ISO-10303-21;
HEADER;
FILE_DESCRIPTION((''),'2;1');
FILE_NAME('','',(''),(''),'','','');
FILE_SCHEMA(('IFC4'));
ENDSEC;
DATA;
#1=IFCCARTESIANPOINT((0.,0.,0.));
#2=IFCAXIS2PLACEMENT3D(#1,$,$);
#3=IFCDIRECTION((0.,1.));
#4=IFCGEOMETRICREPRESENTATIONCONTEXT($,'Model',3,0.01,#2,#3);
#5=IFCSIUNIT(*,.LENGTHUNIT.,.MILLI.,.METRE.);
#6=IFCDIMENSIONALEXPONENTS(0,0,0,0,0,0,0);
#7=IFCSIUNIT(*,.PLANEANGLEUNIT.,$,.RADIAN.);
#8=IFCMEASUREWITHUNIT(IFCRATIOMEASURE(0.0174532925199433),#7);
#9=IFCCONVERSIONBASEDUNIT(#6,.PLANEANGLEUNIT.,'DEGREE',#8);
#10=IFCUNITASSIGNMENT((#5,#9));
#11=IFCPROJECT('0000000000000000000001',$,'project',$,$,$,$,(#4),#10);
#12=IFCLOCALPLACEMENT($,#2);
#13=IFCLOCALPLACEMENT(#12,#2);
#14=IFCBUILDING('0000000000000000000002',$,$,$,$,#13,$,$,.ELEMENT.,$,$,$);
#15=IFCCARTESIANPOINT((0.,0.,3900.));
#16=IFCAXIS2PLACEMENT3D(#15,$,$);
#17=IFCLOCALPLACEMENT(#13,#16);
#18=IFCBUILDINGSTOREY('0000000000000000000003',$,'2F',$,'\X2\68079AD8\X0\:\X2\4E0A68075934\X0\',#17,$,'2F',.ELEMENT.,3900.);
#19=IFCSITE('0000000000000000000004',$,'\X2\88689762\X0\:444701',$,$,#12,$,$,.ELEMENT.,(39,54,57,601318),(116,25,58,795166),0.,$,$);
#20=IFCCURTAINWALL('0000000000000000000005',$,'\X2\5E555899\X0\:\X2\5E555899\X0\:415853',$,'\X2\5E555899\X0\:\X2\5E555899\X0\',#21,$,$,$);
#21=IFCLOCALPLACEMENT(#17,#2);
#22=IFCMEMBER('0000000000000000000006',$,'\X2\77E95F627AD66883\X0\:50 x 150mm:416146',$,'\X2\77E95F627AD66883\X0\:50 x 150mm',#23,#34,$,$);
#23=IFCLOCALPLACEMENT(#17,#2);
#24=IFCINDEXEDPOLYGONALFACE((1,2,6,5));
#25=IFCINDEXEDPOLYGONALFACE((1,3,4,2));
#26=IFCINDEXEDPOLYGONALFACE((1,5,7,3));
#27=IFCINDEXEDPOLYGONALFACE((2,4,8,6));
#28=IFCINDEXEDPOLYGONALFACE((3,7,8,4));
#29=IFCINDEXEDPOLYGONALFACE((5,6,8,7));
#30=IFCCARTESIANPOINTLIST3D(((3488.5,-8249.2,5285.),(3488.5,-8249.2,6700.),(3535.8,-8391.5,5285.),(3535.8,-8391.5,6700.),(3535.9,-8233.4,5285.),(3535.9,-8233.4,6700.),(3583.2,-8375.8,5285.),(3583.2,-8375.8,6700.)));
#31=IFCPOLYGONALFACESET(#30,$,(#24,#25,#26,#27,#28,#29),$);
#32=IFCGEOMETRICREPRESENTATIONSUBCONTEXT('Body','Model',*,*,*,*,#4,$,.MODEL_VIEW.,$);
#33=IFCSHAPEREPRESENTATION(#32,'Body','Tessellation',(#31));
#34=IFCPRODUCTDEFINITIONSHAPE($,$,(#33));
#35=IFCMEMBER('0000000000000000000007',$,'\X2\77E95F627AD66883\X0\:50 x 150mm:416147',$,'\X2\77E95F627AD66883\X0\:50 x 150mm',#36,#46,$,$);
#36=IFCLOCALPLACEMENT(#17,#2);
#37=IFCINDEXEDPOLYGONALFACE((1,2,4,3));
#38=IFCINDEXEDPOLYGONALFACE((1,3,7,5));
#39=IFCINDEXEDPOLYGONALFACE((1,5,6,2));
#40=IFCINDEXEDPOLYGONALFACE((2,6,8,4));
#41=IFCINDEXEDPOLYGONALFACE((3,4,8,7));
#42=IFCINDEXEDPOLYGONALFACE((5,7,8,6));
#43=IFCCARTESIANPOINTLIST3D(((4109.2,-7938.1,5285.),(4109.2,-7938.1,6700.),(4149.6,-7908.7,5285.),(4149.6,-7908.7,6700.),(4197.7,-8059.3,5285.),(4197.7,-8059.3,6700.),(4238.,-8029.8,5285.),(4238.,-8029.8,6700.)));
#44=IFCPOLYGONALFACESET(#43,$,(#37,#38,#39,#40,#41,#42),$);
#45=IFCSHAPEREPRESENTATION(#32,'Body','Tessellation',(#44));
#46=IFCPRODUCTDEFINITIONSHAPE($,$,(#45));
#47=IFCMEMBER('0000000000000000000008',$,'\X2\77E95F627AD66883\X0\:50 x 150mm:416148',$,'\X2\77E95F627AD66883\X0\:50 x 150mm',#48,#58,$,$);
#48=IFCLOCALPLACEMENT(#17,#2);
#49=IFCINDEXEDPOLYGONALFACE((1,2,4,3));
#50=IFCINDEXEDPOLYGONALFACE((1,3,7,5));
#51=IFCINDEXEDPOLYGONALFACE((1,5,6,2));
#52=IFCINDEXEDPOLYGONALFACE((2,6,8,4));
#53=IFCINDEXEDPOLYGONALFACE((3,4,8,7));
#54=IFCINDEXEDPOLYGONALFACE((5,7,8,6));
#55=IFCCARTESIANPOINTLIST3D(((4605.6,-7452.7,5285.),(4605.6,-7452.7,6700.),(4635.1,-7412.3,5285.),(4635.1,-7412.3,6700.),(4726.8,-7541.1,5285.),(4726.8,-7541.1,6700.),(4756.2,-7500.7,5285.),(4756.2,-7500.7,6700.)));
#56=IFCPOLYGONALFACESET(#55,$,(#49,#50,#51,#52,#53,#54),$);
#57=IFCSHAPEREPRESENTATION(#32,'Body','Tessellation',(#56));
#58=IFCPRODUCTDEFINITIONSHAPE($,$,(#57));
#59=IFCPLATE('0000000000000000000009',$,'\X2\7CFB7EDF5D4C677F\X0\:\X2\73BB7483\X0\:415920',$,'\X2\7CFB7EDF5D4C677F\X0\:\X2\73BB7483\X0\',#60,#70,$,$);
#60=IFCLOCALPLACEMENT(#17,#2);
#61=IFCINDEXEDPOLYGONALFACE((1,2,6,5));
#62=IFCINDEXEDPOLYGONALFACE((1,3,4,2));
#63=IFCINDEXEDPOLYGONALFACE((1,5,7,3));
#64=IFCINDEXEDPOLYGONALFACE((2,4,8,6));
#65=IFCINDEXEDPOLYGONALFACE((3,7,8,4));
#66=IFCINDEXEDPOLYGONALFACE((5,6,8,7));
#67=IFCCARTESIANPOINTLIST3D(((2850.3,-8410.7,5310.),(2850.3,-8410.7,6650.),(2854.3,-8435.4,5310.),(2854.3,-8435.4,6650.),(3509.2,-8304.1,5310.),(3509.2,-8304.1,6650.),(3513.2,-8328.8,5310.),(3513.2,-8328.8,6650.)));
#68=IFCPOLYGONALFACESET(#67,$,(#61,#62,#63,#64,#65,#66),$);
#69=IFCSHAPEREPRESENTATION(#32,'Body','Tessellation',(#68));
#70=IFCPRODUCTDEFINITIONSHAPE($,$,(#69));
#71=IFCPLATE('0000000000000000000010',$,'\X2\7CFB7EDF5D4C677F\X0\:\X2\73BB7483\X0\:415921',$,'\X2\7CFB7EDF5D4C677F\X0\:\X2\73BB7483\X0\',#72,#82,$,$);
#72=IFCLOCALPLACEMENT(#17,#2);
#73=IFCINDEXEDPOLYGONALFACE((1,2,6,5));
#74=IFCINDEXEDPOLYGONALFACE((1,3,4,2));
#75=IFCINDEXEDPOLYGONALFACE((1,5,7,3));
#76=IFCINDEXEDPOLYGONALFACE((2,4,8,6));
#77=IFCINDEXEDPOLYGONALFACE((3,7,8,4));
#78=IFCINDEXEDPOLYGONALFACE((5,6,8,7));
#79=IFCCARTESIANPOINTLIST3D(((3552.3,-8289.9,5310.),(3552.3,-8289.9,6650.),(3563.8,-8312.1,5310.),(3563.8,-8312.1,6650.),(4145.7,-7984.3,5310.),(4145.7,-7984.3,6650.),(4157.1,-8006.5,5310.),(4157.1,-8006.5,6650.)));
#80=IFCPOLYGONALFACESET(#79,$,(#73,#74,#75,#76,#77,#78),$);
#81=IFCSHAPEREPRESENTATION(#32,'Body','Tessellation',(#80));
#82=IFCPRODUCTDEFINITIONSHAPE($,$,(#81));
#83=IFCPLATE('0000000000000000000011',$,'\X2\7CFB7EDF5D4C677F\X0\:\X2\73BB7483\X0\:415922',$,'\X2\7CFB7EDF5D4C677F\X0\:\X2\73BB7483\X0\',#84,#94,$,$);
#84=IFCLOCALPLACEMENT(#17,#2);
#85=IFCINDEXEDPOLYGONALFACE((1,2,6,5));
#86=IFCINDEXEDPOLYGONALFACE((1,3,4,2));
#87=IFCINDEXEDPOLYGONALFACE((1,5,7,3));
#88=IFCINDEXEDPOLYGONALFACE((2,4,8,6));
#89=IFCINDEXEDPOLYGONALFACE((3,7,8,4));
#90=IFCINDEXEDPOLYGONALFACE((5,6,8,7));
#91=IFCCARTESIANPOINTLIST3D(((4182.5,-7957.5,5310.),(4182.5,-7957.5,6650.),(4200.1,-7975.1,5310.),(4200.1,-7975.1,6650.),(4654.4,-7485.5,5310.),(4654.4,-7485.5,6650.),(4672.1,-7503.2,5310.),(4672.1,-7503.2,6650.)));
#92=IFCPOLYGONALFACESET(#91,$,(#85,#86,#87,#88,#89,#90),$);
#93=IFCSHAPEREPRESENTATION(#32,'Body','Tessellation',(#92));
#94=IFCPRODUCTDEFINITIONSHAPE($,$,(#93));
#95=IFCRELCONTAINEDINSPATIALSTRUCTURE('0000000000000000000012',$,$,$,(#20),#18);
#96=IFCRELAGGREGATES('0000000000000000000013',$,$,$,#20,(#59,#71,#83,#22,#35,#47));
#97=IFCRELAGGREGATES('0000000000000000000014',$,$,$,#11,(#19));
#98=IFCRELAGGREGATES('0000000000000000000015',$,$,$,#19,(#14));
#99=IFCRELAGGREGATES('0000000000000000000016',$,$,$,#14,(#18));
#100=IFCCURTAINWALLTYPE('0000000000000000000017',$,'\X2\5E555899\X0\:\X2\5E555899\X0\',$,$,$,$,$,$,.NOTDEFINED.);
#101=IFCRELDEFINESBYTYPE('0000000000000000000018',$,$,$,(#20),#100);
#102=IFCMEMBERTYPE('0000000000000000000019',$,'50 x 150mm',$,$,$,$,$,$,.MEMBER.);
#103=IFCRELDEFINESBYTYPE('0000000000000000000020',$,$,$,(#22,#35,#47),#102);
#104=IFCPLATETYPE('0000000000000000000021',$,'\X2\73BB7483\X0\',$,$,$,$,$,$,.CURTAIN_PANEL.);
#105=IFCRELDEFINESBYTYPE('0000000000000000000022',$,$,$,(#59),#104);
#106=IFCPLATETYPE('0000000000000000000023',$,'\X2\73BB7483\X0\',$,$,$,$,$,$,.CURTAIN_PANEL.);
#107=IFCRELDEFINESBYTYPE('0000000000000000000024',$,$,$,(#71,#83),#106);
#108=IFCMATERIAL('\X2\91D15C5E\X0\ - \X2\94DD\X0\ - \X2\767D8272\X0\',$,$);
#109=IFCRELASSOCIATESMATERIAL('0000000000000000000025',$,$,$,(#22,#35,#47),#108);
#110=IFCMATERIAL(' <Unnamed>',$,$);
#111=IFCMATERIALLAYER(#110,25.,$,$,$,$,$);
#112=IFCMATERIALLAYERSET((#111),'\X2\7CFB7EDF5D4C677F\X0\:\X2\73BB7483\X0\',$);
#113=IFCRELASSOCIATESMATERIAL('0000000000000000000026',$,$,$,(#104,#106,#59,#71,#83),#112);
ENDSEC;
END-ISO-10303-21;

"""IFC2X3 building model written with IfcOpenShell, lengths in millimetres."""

from ifc_helpers import new_model, entity, si_unit, converted_unit, direction, frame, frame_2d, origin, origin_2d_with_axis, place, context, subcontext, project, spatial, rectangle, extrude, source, transform, mapped, material, layer, layer_set, layer_usage, type_object, type_shapes, element, aggregate, save


model = new_model("IFC2X3")

# Units and contexts
model_context = context("Model", 3, precision=0.01, world=origin(), true_north=direction((0.0, 1.0)))
body_context = subcontext(model_context, "Body", "Model", "MODEL_VIEW")
ifc_project = project(units=[si_unit("LENGTHUNIT", "METRE", prefix="MILLI"), converted_unit("PLANEANGLEUNIT", "DEGREE", entity("IfcRatioMeasure", 0.0174532925199433), si_unit("PLANEANGLEUNIT", "RADIAN"), dimensions=[0, 0, 0, 0, 0, 0, 0])], contexts=[model_context])

# Site, building, storey
site_placement = place(None, origin())
site = spatial("IfcSite", under=ifc_project, at=site_placement, Name="表面:444701", CompositionType="ELEMENT", RefLatitude=(39, 54, 57, 601318), RefLongitude=(116, 25, 58, 795166), RefElevation=0.0)
building_placement = place(site_placement, origin())
building = spatial("IfcBuilding", under=site, at=building_placement, CompositionType="ELEMENT")
storey_placement = place(building_placement, frame((0.0, 0.0, 3900.0)))
storey = spatial("IfcBuildingStorey", under=building, at=storey_placement, Name="2F", ObjectType="标高:上标头", LongName="2F", CompositionType="ELEMENT", Elevation=3900.0)

# Curtain wall, members
curtain_wall_type = type_object("IfcCurtainWallType", Name="幕墙:幕墙", PredefinedType="NOTDEFINED")
curtain_wall_1_placement = place(storey_placement, frame((0.0, 0.0, -3900.0)))
curtain_wall_1 = element("IfcCurtainWall", 1, at=curtain_wall_1_placement, inside=storey, type_object=curtain_wall_type, Name="幕墙:幕墙:415853", ObjectType="幕墙:幕墙")
ifc_material_1 = material(Name="金属 - 铝 - 白色")
member_type_1 = type_object("IfcMemberType", Name="50 x 150mm", PredefinedType="MEMBER")
shared_shape_1 = source(origin(), body_context, "Body", "SweptSolid", [
    extrude(rectangle(XDim=150.0, YDim=50.0, at=origin_2d_with_axis()), frame((0.0, 0.0, -1415.0), z_axis=(0.0, 0.0, 1.0), x_axis=(0.0, -1.0, 0.0)), (0.0, 0.0, 1.0), 1415.0),
])
type_shapes(member_type_1, [shared_shape_1])
member_1_placement = place(storey_placement, frame((3535.8, -8312.5, 5285.0), z_axis=(0.0, 0.0, -1.0), x_axis=(0.949018, 0.315223, 0.0)))
member_1 = element("IfcMember", 2, at=member_1_placement, type_object=member_type_1, material=ifc_material_1, Name="矩形竖梃:50 x 150mm:416146", ObjectType="矩形竖梃:50 x 150mm", context=body_context, shape_type="MappedRepresentation", body=[
    mapped(shared_shape_1, transform((0.0, 0.0, 0.0), scale=1.0)),
])
member_2_placement = place(storey_placement, frame((4173.6, -7984.0, 5285.0), z_axis=(0.0, 0.0, -1.0), x_axis=(0.807735, 0.589546, 0.0)))
member_2 = element("IfcMember", 3, at=member_2_placement, type_object=member_type_1, material=ifc_material_1, Name="矩形竖梃:50 x 150mm:416147", ObjectType="矩形竖梃:50 x 150mm", context=body_context, shape_type="MappedRepresentation", body=[
    mapped(shared_shape_1, transform((0.0, 0.0, 0.0), scale=1.0)),
])
member_3_placement = place(storey_placement, frame((4680.9, -7476.7, 5285.0), z_axis=(0.0, 0.0, -1.0), x_axis=(0.589546, 0.807735, 0.0)))
member_3 = element("IfcMember", 4, at=member_3_placement, type_object=member_type_1, material=ifc_material_1, Name="矩形竖梃:50 x 150mm:416148", ObjectType="矩形竖梃:50 x 150mm", context=body_context, shape_type="MappedRepresentation", body=[
    mapped(shared_shape_1, transform((0.0, 0.0, 0.0), scale=1.0)),
])

# Plates
ifc_material_2 = material(Name=" <Unnamed>")
ifc_layer = layer(ifc_material_2, 25.0)
ifc_layer_set = layer_set([ifc_layer], Name="系统嵌板:玻璃")
ifc_layer_usage_1 = layer_usage(ifc_layer_set, "AXIS3", "POSITIVE", 0.0)
plate_type_1 = type_object("IfcPlateType", Name="玻璃", PredefinedType="CURTAIN_PANEL", material=ifc_layer_set)
shared_shape_2 = source(origin(), body_context, "Body", "SweptSolid", [
    extrude(rectangle(XDim=25.0, YDim=667.4, at=frame_2d((0.0, 0.0), x_axis=(1.0, 0.0))), frame((0.0, 0.0, 0.0), z_axis=(0.0, 0.0, 1.0), x_axis=(0.0, 1.0, 0.0)), (0.0, 0.0, 1.0), 1340.0),
])
type_shapes(plate_type_1, [shared_shape_2])
plate_1_placement = place(curtain_wall_1_placement, frame((3181.7, -8369.7, 9210.0), z_axis=(0.0, 0.0, 1.0), x_axis=(0.987172, 0.15966, 0.0)))
plate_1 = element("IfcPlate", 5, at=plate_1_placement, type_object=plate_type_1, material=ifc_layer_usage_1, Name="系统嵌板:玻璃:415920", ObjectType="系统嵌板:玻璃", context=body_context, shape_type="MappedRepresentation", body=[
    mapped(shared_shape_2, transform((0.0, 0.0, 0.0), scale=1.0)),
])
ifc_layer_usage_2 = layer_usage(ifc_layer_set, "AXIS3", "POSITIVE", 0.0)
plate_type_2 = type_object("IfcPlateType", Name="玻璃", PredefinedType="CURTAIN_PANEL", material=ifc_layer_set)
shared_shape_3 = source(origin(), body_context, "Body", "SweptSolid", [
    extrude(rectangle(XDim=25.0, YDim=667.4, at=frame_2d((0.0, 0.0), x_axis=(1.0, 0.0))), frame((0.0, 0.0, 0.0), z_axis=(0.0, 0.0, 1.0), x_axis=(0.0, 1.0, 0.0)), (0.0, 0.0, 1.0), 1340.0),
])
type_shapes(plate_type_2, [shared_shape_3])
plate_2_placement = place(curtain_wall_1_placement, frame((3854.7, -8148.2, 9210.0), z_axis=(0.0, 0.0, 1.0), x_axis=(0.889021, 0.457867, 0.0)))
plate_2 = element("IfcPlate", 6, at=plate_2_placement, type_object=plate_type_2, material=ifc_layer_usage_2, Name="系统嵌板:玻璃:415921", ObjectType="系统嵌板:玻璃", context=body_context, shape_type="MappedRepresentation", body=[
    mapped(shared_shape_3, transform((0.0, 0.0, 0.0), scale=1.0)),
])
ifc_layer_usage_3 = layer_usage(ifc_layer_set, "AXIS3", "POSITIVE", 0.0)
plate_3_placement = place(curtain_wall_1_placement, frame((4427.3, -7730.3, 9210.0), z_axis=(0.0, 0.0, 1.0), x_axis=(0.707107, 0.707107, 0.0)))
plate_3 = element("IfcPlate", 7, at=plate_3_placement, type_object=plate_type_2, material=ifc_layer_usage_3, Name="系统嵌板:玻璃:415922", ObjectType="系统嵌板:玻璃", context=body_context, shape_type="MappedRepresentation", body=[
    mapped(shared_shape_3, transform((0.0, 0.0, 0.0), scale=1.0)),
])
aggregate(curtain_wall_1, [plate_1, plate_2, plate_3, member_1, member_2, member_3])

save(model, "model.ifc")
